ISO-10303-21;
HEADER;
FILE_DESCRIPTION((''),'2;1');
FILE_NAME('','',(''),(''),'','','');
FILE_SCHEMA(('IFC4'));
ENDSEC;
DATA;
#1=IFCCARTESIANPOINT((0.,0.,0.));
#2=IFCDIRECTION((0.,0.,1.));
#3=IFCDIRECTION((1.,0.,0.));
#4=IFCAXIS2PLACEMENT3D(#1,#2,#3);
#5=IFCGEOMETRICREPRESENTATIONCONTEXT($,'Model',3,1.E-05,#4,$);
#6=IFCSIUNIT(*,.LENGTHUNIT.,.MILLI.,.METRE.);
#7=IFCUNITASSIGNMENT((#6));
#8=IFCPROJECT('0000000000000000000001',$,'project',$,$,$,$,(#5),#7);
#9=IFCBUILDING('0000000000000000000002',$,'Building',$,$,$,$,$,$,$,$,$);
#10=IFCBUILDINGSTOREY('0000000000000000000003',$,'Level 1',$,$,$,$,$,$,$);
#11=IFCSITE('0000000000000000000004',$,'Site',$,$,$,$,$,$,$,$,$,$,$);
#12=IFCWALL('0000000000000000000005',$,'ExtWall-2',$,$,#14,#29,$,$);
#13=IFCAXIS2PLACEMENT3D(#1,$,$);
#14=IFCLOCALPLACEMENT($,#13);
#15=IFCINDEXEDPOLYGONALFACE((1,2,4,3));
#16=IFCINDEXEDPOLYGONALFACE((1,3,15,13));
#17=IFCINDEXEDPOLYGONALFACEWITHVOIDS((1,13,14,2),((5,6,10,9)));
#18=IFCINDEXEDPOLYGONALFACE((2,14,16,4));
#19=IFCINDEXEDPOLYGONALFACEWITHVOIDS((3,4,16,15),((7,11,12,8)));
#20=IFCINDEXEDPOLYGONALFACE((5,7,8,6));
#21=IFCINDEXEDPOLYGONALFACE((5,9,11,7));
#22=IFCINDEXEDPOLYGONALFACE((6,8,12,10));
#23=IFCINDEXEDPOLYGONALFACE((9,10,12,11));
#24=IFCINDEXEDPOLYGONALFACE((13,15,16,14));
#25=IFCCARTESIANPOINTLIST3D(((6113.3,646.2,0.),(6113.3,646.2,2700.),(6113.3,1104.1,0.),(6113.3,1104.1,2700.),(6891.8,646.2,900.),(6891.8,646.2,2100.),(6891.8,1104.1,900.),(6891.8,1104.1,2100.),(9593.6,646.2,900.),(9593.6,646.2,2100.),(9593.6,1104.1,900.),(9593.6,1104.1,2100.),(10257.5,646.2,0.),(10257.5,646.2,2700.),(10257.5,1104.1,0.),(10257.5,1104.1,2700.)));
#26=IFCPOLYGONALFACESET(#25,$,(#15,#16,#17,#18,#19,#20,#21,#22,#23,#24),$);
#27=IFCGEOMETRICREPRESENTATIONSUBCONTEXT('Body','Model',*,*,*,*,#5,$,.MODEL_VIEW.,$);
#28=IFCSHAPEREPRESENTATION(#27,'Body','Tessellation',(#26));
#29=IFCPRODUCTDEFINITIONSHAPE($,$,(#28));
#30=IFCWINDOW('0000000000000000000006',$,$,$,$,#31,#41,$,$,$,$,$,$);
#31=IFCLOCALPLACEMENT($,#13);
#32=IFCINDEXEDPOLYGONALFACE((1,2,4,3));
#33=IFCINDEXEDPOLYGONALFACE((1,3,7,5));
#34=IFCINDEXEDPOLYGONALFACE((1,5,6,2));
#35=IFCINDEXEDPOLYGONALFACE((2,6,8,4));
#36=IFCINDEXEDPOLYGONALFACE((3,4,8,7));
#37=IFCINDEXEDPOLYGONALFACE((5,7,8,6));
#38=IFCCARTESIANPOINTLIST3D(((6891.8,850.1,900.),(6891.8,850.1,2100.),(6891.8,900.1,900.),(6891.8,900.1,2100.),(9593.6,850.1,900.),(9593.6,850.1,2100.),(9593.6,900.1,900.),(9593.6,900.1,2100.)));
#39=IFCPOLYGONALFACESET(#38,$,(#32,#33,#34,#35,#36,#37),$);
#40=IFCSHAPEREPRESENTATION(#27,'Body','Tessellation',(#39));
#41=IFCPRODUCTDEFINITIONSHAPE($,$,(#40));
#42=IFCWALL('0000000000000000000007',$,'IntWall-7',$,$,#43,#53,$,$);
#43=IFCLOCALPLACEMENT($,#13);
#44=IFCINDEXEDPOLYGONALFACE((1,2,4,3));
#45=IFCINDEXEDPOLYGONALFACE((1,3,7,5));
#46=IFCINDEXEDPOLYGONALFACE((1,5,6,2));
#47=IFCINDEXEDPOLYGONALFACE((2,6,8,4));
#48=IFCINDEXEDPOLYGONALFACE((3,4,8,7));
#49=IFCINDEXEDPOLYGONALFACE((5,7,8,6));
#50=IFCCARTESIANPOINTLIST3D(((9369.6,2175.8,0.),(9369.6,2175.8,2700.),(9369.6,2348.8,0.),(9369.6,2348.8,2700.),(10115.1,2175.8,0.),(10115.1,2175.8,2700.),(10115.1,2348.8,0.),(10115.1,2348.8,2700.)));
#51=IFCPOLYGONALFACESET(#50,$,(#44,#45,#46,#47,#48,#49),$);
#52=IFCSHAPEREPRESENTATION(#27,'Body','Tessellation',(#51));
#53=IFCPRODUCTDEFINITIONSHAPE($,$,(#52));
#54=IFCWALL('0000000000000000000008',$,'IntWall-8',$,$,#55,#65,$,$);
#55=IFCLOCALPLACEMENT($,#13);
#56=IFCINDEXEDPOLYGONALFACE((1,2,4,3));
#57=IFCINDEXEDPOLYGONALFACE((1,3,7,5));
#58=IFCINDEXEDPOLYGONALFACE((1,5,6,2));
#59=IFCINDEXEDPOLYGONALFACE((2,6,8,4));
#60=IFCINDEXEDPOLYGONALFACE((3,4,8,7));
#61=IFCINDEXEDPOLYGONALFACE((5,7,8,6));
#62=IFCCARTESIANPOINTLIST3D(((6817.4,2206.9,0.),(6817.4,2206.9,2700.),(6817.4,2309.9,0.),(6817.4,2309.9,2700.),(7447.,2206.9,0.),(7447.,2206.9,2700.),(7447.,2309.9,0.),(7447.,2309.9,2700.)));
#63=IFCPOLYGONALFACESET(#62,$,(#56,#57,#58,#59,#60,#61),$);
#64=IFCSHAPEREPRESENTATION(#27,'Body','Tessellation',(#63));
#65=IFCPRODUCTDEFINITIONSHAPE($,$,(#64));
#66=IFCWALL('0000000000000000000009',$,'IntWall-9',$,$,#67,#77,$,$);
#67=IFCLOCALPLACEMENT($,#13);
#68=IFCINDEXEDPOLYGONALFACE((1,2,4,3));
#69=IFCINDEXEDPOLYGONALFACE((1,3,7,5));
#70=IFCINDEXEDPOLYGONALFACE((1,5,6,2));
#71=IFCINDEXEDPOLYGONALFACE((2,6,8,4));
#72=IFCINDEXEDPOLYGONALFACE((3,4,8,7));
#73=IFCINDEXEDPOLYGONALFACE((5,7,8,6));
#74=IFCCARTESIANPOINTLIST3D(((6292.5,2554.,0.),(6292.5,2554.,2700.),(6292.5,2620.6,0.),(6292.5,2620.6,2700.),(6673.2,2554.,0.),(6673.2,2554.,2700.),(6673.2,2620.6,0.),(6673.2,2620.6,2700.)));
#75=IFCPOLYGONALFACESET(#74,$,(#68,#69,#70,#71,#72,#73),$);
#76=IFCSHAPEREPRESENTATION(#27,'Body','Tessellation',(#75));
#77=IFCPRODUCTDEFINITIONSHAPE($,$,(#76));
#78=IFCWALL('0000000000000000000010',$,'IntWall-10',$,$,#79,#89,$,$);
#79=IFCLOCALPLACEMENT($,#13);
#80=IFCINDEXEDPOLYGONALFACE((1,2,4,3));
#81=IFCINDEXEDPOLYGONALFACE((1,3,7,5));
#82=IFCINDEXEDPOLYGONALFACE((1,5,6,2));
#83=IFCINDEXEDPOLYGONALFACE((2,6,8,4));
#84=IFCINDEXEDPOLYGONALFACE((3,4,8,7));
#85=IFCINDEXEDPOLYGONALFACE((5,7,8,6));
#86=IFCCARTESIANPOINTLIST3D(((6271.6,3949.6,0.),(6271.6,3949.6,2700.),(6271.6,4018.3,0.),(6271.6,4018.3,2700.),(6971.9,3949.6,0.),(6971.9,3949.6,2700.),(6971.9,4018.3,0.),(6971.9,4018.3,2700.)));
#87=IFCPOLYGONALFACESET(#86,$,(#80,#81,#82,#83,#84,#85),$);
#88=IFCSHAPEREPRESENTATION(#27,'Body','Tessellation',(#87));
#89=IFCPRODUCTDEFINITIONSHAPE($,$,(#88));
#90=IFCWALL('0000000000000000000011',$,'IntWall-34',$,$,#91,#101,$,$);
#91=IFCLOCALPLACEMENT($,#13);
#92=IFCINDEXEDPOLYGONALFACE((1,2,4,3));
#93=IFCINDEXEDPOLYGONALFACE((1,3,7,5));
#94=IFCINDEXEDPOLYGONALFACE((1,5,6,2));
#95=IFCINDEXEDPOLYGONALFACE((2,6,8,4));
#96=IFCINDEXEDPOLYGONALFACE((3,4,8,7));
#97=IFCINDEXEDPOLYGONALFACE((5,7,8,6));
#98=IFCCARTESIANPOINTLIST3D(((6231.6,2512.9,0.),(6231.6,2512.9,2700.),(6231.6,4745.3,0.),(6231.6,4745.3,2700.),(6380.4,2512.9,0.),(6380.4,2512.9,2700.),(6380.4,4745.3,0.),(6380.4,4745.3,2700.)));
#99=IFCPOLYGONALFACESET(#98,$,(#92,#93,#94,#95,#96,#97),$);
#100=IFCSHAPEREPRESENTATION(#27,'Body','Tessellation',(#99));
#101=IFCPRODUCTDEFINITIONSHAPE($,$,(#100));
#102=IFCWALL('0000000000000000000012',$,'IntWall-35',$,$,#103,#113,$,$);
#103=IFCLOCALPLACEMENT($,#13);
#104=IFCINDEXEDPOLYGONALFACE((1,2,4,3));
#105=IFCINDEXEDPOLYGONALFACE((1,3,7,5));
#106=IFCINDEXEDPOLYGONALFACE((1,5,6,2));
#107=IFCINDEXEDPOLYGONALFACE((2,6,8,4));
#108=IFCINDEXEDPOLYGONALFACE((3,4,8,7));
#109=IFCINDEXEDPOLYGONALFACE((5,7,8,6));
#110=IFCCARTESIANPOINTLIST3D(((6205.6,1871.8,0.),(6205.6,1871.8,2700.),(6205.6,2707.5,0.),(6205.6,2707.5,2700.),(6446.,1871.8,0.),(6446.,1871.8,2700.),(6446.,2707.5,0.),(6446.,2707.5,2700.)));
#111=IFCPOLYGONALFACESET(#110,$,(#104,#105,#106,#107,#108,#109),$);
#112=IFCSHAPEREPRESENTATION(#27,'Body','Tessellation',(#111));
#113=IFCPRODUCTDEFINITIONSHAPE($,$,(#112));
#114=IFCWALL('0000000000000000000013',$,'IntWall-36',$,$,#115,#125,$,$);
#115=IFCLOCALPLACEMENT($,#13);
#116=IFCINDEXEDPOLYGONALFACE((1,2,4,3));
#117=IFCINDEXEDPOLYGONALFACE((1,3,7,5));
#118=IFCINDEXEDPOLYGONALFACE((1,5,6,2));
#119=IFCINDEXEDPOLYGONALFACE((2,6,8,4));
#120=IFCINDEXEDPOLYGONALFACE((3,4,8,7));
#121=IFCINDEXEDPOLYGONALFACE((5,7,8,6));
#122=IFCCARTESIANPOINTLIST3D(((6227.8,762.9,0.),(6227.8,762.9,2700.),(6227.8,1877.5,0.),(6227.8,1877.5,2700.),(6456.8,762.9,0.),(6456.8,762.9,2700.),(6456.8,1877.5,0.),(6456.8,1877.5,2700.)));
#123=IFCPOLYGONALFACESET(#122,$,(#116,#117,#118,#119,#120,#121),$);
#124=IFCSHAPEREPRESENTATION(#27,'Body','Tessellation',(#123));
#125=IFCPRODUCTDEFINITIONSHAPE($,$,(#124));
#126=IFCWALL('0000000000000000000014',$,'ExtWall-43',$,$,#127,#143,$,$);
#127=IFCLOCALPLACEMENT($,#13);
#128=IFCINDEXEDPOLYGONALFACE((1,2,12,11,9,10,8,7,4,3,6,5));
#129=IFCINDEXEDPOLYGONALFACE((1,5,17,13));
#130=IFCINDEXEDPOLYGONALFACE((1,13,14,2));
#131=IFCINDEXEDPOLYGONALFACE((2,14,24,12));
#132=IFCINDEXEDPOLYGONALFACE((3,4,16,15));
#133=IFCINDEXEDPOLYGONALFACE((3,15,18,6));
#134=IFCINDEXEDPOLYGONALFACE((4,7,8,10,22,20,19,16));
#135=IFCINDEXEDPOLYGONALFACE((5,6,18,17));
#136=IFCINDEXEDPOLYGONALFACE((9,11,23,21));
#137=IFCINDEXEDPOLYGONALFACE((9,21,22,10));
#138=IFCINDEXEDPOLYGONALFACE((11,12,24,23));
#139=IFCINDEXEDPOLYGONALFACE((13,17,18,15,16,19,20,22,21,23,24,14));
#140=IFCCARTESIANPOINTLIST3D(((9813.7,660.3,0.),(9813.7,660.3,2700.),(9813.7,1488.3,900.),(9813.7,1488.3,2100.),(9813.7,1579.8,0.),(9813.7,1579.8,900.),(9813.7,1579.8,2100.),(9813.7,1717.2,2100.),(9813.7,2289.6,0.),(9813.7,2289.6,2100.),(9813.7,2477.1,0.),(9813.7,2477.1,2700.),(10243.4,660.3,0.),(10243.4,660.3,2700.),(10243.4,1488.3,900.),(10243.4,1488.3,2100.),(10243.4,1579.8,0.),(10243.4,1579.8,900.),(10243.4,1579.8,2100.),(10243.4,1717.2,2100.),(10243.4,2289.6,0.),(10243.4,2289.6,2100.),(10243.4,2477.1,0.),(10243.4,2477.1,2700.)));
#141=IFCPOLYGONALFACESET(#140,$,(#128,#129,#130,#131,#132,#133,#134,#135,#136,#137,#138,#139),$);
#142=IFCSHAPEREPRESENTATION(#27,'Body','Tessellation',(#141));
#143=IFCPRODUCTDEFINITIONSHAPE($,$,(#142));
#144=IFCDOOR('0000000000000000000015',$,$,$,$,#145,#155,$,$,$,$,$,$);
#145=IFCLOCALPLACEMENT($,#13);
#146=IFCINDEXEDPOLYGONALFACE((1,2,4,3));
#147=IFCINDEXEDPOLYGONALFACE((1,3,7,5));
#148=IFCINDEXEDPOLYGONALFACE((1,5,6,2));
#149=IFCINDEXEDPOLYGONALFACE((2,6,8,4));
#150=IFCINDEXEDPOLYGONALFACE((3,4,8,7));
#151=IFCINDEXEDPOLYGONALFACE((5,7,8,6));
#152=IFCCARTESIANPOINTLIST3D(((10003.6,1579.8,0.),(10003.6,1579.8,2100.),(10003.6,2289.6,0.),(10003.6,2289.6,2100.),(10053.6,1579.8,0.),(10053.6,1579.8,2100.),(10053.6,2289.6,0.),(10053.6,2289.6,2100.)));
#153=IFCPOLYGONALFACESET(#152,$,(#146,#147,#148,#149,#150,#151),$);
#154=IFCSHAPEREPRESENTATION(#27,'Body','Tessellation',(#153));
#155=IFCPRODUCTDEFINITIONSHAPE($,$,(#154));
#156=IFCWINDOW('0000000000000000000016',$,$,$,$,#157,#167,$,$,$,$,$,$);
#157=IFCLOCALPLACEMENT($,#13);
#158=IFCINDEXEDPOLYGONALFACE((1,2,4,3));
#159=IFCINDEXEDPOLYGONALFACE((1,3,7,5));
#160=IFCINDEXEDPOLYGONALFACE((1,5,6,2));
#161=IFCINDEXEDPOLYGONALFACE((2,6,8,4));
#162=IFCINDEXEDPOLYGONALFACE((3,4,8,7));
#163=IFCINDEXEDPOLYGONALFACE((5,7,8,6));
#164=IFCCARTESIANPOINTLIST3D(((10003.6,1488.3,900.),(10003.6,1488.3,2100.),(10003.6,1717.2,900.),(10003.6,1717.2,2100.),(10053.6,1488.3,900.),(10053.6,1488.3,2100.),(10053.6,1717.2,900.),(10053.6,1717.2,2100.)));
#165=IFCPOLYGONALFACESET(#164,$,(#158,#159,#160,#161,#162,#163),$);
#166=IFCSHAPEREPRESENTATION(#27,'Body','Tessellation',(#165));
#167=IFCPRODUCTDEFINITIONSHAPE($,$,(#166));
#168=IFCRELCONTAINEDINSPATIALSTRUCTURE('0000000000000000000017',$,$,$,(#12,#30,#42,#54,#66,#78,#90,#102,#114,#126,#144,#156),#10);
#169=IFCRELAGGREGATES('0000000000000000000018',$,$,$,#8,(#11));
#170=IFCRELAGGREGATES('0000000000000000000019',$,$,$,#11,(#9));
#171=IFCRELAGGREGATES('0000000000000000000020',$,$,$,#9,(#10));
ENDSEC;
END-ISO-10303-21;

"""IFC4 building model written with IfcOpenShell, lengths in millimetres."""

from ifc_helpers import new_model, si_unit, frame, origin_with_axes, place, context, subcontext, project, spatial, indexed_curve, outline, extrude, element, fill, save


model = new_model("IFC4")

# Units and contexts
model_context = context("Model", 3, precision=1e-05, world=origin_with_axes())
body_context = subcontext(model_context, "Body", "Model", "MODEL_VIEW")
ifc_project = project(units=[si_unit("LENGTHUNIT", "METRE", prefix="MILLI")], contexts=[model_context])

# Site, building, storey
site = spatial("IfcSite", under=ifc_project, Name="Site")
building = spatial("IfcBuilding", under=site, Name="Building")
storey = spatial("IfcBuildingStorey", under=building, Name="Level 1")

# Wall, opening, window
wall_1_placement = place(None, frame((6113.3, 875.1, 0.0), z_axis=(0.0, 0.0, 1.0), x_axis=(1.0, 0.0, 0.0)))
wall_1 = element("IfcWall", 1, at=wall_1_placement, inside=storey, Name="ExtWall-2", context=body_context, shape_type="SweptSolid", body=[
    extrude(outline(indexed_curve([(0.0, 0.0), (0.0, 457.9), (4144.2, 457.9), (4144.2, 0.0), (0.0, 0.0)], self_intersect=False)), frame((0.0, -229.0, 0.0), z_axis=(0.0, 0.0, 1.0), x_axis=(1.0, 0.0, 0.0)), (0.0, 0.0, 1.0), 2700.0),
])
opening_1_placement = place(wall_1_placement, frame((778.5, 0.0, 900.0), z_axis=(0.0, 0.0, 1.0), x_axis=(1.0, 0.0, 0.0)))
opening_1 = element("IfcOpeningElement", 2, at=opening_1_placement, cuts=wall_1, context=body_context, shape_type="SweptSolid", body=[
    extrude(outline(indexed_curve([(0.0, 0.0), (0.0, 557.9), (2701.8, 557.9), (2701.8, 0.0), (0.0, 0.0)], self_intersect=False)), frame((0.0, -279.0, 0.0), z_axis=(0.0, 0.0, 1.0), x_axis=(1.0, 0.0, 0.0)), (0.0, 0.0, 1.0), 1200.0),
])
window_1_placement = place(opening_1_placement, frame((0.0, 0.0, 0.0), z_axis=(0.0, 0.0, 1.0), x_axis=(1.0, 0.0, 0.0)))
window_1 = element("IfcWindow", 3, at=window_1_placement, inside=storey, context=body_context, shape_type="SweptSolid", body=[
    extrude(outline(indexed_curve([(0.0, 0.0), (0.0, 50.0), (2701.8, 50.0), (2701.8, 0.0), (0.0, 0.0)], self_intersect=False)), frame((0.0, -25.0, 0.0), z_axis=(0.0, 0.0, 1.0), x_axis=(1.0, 0.0, 0.0)), (0.0, 0.0, 1.0), 1200.0),
])
fill(opening_1, window_1)

# Walls
wall_2_placement = place(None, frame((9369.6, 2262.3, 0.0), z_axis=(0.0, 0.0, 1.0), x_axis=(1.0, 0.0, 0.0)))
element("IfcWall", 4, at=wall_2_placement, inside=storey, Name="IntWall-7", context=body_context, shape_type="SweptSolid", body=[
    extrude(outline(indexed_curve([(0.0, 0.0), (0.0, 173.1), (745.5, 173.1), (745.5, 0.0), (0.0, 0.0)], self_intersect=False)), frame((0.0, -86.5, 0.0), z_axis=(0.0, 0.0, 1.0), x_axis=(1.0, 0.0, 0.0)), (0.0, 0.0, 1.0), 2700.0),
])
wall_3_placement = place(None, frame((6817.4, 2258.4, 0.0), z_axis=(0.0, 0.0, 1.0), x_axis=(1.0, 0.0, 0.0)))
element("IfcWall", 5, at=wall_3_placement, inside=storey, Name="IntWall-8", context=body_context, shape_type="SweptSolid", body=[
    extrude(outline(indexed_curve([(0.0, 0.0), (0.0, 103.0), (629.6, 103.0), (629.6, 0.0), (0.0, 0.0)], self_intersect=False)), frame((0.0, -51.5, 0.0), z_axis=(0.0, 0.0, 1.0), x_axis=(1.0, 0.0, 0.0)), (0.0, 0.0, 1.0), 2700.0),
])
wall_4_placement = place(None, frame((6292.5, 2587.3, 0.0), z_axis=(0.0, 0.0, 1.0), x_axis=(1.0, 0.0, 0.0)))
element("IfcWall", 6, at=wall_4_placement, inside=storey, Name="IntWall-9", context=body_context, shape_type="SweptSolid", body=[
    extrude(outline(indexed_curve([(0.0, 0.0), (0.0, 66.6), (380.8, 66.6), (380.8, 0.0), (0.0, 0.0)], self_intersect=False)), frame((0.0, -33.3, 0.0), z_axis=(0.0, 0.0, 1.0), x_axis=(1.0, 0.0, 0.0)), (0.0, 0.0, 1.0), 2700.0),
])
wall_5_placement = place(None, frame((6271.6, 3984.0, 0.0), z_axis=(0.0, 0.0, 1.0), x_axis=(1.0, 0.0, 0.0)))
element("IfcWall", 7, at=wall_5_placement, inside=storey, Name="IntWall-10", context=body_context, shape_type="SweptSolid", body=[
    extrude(outline(indexed_curve([(0.0, 0.0), (0.0, 68.7), (700.3, 68.7), (700.3, 0.0), (0.0, 0.0)], self_intersect=False)), frame((0.0, -34.3, 0.0), z_axis=(0.0, 0.0, 1.0), x_axis=(1.0, 0.0, 0.0)), (0.0, 0.0, 1.0), 2700.0),
])
wall_6_placement = place(None, frame((6306.0, 2512.9, 0.0), z_axis=(0.0, 0.0, 1.0), x_axis=(0.0, 1.0, 0.0)))
element("IfcWall", 8, at=wall_6_placement, inside=storey, Name="IntWall-34", context=body_context, shape_type="SweptSolid", body=[
    extrude(outline(indexed_curve([(0.0, 0.0), (0.0, 148.8), (2232.4, 148.8), (2232.4, 0.0), (0.0, 0.0)], self_intersect=False)), frame((0.0, -74.4, 0.0), z_axis=(0.0, 0.0, 1.0), x_axis=(1.0, 0.0, 0.0)), (0.0, 0.0, 1.0), 2700.0),
])
wall_7_placement = place(None, frame((6325.8, 1871.8, 0.0), z_axis=(0.0, 0.0, 1.0), x_axis=(0.0, 1.0, 0.0)))
element("IfcWall", 9, at=wall_7_placement, inside=storey, Name="IntWall-35", context=body_context, shape_type="SweptSolid", body=[
    extrude(outline(indexed_curve([(0.0, 0.0), (0.0, 240.4), (835.7, 240.4), (835.7, 0.0), (0.0, 0.0)], self_intersect=False)), frame((0.0, -120.2, 0.0), z_axis=(0.0, 0.0, 1.0), x_axis=(1.0, 0.0, 0.0)), (0.0, 0.0, 1.0), 2700.0),
])
wall_8_placement = place(None, frame((6342.3, 762.9, 0.0), z_axis=(0.0, 0.0, 1.0), x_axis=(0.0, 1.0, 0.0)))
element("IfcWall", 10, at=wall_8_placement, inside=storey, Name="IntWall-36", context=body_context, shape_type="SweptSolid", body=[
    extrude(outline(indexed_curve([(0.0, 0.0), (0.0, 229.0), (1114.6, 229.0), (1114.6, 0.0), (0.0, 0.0)], self_intersect=False)), frame((0.0, -114.5, 0.0), z_axis=(0.0, 0.0, 1.0), x_axis=(1.0, 0.0, 0.0)), (0.0, 0.0, 1.0), 2700.0),
])

# Wall, openings, door, window
wall_9_placement = place(None, frame((10028.6, 660.3, 0.0), z_axis=(0.0, 0.0, 1.0), x_axis=(0.0, 1.0, 0.0)))
wall_9 = element("IfcWall", 11, at=wall_9_placement, inside=storey, Name="ExtWall-43", context=body_context, shape_type="SweptSolid", body=[
    extrude(outline(indexed_curve([(0.0, 0.0), (0.0, 429.7), (1816.8, 429.7), (1816.8, 0.0), (0.0, 0.0)], self_intersect=False)), frame((0.0, -214.8, 0.0), z_axis=(0.0, 0.0, 1.0), x_axis=(1.0, 0.0, 0.0)), (0.0, 0.0, 1.0), 2700.0),
])
opening_2_placement = place(wall_9_placement, frame((919.5, 0.0, 0.0), z_axis=(0.0, 0.0, 1.0), x_axis=(1.0, 0.0, 0.0)))
opening_2 = element("IfcOpeningElement", 12, at=opening_2_placement, cuts=wall_9, context=body_context, shape_type="SweptSolid", body=[
    extrude(outline(indexed_curve([(0.0, 0.0), (0.0, 529.7), (709.8, 529.7), (709.8, 0.0), (0.0, 0.0)], self_intersect=False)), frame((0.0, -264.8, 0.0), z_axis=(0.0, 0.0, 1.0), x_axis=(1.0, 0.0, 0.0)), (0.0, 0.0, 1.0), 2100.0),
])
opening_3_placement = place(wall_9_placement, frame((828.0, 0.0, 900.0), z_axis=(0.0, 0.0, 1.0), x_axis=(1.0, 0.0, 0.0)))
opening_3 = element("IfcOpeningElement", 13, at=opening_3_placement, cuts=wall_9, context=body_context, shape_type="SweptSolid", body=[
    extrude(outline(indexed_curve([(0.0, 0.0), (0.0, 529.7), (229.0, 529.7), (229.0, 0.0), (0.0, 0.0)], self_intersect=False)), frame((0.0, -264.8, 0.0), z_axis=(0.0, 0.0, 1.0), x_axis=(1.0, 0.0, 0.0)), (0.0, 0.0, 1.0), 1200.0),
])
door_placement = place(opening_2_placement, origin_with_axes())
door = element("IfcDoor", 14, at=door_placement, inside=storey, context=body_context, shape_type="SweptSolid", body=[
    extrude(outline(indexed_curve([(0.0, 0.0), (0.0, 50.0), (709.8, 50.0), (709.8, 0.0), (0.0, 0.0)], self_intersect=False)), frame((0.0, -25.0, 0.0), z_axis=(0.0, 0.0, 1.0), x_axis=(1.0, 0.0, 0.0)), (0.0, 0.0, 1.0), 2100.0),
])
fill(opening_2, door)
window_2_placement = place(opening_3_placement, frame((0.0, 0.0, 0.0), z_axis=(0.0, 0.0, 1.0), x_axis=(1.0, 0.0, 0.0)))
window_2 = element("IfcWindow", 15, at=window_2_placement, inside=storey, context=body_context, shape_type="SweptSolid", body=[
    extrude(outline(indexed_curve([(0.0, 0.0), (0.0, 50.0), (229.0, 50.0), (229.0, 0.0), (0.0, 0.0)], self_intersect=False)), frame((0.0, -25.0, 0.0), z_axis=(0.0, 0.0, 1.0), x_axis=(1.0, 0.0, 0.0)), (0.0, 0.0, 1.0), 1200.0),
])
fill(opening_3, window_2)

save(model, "model.ifc")
